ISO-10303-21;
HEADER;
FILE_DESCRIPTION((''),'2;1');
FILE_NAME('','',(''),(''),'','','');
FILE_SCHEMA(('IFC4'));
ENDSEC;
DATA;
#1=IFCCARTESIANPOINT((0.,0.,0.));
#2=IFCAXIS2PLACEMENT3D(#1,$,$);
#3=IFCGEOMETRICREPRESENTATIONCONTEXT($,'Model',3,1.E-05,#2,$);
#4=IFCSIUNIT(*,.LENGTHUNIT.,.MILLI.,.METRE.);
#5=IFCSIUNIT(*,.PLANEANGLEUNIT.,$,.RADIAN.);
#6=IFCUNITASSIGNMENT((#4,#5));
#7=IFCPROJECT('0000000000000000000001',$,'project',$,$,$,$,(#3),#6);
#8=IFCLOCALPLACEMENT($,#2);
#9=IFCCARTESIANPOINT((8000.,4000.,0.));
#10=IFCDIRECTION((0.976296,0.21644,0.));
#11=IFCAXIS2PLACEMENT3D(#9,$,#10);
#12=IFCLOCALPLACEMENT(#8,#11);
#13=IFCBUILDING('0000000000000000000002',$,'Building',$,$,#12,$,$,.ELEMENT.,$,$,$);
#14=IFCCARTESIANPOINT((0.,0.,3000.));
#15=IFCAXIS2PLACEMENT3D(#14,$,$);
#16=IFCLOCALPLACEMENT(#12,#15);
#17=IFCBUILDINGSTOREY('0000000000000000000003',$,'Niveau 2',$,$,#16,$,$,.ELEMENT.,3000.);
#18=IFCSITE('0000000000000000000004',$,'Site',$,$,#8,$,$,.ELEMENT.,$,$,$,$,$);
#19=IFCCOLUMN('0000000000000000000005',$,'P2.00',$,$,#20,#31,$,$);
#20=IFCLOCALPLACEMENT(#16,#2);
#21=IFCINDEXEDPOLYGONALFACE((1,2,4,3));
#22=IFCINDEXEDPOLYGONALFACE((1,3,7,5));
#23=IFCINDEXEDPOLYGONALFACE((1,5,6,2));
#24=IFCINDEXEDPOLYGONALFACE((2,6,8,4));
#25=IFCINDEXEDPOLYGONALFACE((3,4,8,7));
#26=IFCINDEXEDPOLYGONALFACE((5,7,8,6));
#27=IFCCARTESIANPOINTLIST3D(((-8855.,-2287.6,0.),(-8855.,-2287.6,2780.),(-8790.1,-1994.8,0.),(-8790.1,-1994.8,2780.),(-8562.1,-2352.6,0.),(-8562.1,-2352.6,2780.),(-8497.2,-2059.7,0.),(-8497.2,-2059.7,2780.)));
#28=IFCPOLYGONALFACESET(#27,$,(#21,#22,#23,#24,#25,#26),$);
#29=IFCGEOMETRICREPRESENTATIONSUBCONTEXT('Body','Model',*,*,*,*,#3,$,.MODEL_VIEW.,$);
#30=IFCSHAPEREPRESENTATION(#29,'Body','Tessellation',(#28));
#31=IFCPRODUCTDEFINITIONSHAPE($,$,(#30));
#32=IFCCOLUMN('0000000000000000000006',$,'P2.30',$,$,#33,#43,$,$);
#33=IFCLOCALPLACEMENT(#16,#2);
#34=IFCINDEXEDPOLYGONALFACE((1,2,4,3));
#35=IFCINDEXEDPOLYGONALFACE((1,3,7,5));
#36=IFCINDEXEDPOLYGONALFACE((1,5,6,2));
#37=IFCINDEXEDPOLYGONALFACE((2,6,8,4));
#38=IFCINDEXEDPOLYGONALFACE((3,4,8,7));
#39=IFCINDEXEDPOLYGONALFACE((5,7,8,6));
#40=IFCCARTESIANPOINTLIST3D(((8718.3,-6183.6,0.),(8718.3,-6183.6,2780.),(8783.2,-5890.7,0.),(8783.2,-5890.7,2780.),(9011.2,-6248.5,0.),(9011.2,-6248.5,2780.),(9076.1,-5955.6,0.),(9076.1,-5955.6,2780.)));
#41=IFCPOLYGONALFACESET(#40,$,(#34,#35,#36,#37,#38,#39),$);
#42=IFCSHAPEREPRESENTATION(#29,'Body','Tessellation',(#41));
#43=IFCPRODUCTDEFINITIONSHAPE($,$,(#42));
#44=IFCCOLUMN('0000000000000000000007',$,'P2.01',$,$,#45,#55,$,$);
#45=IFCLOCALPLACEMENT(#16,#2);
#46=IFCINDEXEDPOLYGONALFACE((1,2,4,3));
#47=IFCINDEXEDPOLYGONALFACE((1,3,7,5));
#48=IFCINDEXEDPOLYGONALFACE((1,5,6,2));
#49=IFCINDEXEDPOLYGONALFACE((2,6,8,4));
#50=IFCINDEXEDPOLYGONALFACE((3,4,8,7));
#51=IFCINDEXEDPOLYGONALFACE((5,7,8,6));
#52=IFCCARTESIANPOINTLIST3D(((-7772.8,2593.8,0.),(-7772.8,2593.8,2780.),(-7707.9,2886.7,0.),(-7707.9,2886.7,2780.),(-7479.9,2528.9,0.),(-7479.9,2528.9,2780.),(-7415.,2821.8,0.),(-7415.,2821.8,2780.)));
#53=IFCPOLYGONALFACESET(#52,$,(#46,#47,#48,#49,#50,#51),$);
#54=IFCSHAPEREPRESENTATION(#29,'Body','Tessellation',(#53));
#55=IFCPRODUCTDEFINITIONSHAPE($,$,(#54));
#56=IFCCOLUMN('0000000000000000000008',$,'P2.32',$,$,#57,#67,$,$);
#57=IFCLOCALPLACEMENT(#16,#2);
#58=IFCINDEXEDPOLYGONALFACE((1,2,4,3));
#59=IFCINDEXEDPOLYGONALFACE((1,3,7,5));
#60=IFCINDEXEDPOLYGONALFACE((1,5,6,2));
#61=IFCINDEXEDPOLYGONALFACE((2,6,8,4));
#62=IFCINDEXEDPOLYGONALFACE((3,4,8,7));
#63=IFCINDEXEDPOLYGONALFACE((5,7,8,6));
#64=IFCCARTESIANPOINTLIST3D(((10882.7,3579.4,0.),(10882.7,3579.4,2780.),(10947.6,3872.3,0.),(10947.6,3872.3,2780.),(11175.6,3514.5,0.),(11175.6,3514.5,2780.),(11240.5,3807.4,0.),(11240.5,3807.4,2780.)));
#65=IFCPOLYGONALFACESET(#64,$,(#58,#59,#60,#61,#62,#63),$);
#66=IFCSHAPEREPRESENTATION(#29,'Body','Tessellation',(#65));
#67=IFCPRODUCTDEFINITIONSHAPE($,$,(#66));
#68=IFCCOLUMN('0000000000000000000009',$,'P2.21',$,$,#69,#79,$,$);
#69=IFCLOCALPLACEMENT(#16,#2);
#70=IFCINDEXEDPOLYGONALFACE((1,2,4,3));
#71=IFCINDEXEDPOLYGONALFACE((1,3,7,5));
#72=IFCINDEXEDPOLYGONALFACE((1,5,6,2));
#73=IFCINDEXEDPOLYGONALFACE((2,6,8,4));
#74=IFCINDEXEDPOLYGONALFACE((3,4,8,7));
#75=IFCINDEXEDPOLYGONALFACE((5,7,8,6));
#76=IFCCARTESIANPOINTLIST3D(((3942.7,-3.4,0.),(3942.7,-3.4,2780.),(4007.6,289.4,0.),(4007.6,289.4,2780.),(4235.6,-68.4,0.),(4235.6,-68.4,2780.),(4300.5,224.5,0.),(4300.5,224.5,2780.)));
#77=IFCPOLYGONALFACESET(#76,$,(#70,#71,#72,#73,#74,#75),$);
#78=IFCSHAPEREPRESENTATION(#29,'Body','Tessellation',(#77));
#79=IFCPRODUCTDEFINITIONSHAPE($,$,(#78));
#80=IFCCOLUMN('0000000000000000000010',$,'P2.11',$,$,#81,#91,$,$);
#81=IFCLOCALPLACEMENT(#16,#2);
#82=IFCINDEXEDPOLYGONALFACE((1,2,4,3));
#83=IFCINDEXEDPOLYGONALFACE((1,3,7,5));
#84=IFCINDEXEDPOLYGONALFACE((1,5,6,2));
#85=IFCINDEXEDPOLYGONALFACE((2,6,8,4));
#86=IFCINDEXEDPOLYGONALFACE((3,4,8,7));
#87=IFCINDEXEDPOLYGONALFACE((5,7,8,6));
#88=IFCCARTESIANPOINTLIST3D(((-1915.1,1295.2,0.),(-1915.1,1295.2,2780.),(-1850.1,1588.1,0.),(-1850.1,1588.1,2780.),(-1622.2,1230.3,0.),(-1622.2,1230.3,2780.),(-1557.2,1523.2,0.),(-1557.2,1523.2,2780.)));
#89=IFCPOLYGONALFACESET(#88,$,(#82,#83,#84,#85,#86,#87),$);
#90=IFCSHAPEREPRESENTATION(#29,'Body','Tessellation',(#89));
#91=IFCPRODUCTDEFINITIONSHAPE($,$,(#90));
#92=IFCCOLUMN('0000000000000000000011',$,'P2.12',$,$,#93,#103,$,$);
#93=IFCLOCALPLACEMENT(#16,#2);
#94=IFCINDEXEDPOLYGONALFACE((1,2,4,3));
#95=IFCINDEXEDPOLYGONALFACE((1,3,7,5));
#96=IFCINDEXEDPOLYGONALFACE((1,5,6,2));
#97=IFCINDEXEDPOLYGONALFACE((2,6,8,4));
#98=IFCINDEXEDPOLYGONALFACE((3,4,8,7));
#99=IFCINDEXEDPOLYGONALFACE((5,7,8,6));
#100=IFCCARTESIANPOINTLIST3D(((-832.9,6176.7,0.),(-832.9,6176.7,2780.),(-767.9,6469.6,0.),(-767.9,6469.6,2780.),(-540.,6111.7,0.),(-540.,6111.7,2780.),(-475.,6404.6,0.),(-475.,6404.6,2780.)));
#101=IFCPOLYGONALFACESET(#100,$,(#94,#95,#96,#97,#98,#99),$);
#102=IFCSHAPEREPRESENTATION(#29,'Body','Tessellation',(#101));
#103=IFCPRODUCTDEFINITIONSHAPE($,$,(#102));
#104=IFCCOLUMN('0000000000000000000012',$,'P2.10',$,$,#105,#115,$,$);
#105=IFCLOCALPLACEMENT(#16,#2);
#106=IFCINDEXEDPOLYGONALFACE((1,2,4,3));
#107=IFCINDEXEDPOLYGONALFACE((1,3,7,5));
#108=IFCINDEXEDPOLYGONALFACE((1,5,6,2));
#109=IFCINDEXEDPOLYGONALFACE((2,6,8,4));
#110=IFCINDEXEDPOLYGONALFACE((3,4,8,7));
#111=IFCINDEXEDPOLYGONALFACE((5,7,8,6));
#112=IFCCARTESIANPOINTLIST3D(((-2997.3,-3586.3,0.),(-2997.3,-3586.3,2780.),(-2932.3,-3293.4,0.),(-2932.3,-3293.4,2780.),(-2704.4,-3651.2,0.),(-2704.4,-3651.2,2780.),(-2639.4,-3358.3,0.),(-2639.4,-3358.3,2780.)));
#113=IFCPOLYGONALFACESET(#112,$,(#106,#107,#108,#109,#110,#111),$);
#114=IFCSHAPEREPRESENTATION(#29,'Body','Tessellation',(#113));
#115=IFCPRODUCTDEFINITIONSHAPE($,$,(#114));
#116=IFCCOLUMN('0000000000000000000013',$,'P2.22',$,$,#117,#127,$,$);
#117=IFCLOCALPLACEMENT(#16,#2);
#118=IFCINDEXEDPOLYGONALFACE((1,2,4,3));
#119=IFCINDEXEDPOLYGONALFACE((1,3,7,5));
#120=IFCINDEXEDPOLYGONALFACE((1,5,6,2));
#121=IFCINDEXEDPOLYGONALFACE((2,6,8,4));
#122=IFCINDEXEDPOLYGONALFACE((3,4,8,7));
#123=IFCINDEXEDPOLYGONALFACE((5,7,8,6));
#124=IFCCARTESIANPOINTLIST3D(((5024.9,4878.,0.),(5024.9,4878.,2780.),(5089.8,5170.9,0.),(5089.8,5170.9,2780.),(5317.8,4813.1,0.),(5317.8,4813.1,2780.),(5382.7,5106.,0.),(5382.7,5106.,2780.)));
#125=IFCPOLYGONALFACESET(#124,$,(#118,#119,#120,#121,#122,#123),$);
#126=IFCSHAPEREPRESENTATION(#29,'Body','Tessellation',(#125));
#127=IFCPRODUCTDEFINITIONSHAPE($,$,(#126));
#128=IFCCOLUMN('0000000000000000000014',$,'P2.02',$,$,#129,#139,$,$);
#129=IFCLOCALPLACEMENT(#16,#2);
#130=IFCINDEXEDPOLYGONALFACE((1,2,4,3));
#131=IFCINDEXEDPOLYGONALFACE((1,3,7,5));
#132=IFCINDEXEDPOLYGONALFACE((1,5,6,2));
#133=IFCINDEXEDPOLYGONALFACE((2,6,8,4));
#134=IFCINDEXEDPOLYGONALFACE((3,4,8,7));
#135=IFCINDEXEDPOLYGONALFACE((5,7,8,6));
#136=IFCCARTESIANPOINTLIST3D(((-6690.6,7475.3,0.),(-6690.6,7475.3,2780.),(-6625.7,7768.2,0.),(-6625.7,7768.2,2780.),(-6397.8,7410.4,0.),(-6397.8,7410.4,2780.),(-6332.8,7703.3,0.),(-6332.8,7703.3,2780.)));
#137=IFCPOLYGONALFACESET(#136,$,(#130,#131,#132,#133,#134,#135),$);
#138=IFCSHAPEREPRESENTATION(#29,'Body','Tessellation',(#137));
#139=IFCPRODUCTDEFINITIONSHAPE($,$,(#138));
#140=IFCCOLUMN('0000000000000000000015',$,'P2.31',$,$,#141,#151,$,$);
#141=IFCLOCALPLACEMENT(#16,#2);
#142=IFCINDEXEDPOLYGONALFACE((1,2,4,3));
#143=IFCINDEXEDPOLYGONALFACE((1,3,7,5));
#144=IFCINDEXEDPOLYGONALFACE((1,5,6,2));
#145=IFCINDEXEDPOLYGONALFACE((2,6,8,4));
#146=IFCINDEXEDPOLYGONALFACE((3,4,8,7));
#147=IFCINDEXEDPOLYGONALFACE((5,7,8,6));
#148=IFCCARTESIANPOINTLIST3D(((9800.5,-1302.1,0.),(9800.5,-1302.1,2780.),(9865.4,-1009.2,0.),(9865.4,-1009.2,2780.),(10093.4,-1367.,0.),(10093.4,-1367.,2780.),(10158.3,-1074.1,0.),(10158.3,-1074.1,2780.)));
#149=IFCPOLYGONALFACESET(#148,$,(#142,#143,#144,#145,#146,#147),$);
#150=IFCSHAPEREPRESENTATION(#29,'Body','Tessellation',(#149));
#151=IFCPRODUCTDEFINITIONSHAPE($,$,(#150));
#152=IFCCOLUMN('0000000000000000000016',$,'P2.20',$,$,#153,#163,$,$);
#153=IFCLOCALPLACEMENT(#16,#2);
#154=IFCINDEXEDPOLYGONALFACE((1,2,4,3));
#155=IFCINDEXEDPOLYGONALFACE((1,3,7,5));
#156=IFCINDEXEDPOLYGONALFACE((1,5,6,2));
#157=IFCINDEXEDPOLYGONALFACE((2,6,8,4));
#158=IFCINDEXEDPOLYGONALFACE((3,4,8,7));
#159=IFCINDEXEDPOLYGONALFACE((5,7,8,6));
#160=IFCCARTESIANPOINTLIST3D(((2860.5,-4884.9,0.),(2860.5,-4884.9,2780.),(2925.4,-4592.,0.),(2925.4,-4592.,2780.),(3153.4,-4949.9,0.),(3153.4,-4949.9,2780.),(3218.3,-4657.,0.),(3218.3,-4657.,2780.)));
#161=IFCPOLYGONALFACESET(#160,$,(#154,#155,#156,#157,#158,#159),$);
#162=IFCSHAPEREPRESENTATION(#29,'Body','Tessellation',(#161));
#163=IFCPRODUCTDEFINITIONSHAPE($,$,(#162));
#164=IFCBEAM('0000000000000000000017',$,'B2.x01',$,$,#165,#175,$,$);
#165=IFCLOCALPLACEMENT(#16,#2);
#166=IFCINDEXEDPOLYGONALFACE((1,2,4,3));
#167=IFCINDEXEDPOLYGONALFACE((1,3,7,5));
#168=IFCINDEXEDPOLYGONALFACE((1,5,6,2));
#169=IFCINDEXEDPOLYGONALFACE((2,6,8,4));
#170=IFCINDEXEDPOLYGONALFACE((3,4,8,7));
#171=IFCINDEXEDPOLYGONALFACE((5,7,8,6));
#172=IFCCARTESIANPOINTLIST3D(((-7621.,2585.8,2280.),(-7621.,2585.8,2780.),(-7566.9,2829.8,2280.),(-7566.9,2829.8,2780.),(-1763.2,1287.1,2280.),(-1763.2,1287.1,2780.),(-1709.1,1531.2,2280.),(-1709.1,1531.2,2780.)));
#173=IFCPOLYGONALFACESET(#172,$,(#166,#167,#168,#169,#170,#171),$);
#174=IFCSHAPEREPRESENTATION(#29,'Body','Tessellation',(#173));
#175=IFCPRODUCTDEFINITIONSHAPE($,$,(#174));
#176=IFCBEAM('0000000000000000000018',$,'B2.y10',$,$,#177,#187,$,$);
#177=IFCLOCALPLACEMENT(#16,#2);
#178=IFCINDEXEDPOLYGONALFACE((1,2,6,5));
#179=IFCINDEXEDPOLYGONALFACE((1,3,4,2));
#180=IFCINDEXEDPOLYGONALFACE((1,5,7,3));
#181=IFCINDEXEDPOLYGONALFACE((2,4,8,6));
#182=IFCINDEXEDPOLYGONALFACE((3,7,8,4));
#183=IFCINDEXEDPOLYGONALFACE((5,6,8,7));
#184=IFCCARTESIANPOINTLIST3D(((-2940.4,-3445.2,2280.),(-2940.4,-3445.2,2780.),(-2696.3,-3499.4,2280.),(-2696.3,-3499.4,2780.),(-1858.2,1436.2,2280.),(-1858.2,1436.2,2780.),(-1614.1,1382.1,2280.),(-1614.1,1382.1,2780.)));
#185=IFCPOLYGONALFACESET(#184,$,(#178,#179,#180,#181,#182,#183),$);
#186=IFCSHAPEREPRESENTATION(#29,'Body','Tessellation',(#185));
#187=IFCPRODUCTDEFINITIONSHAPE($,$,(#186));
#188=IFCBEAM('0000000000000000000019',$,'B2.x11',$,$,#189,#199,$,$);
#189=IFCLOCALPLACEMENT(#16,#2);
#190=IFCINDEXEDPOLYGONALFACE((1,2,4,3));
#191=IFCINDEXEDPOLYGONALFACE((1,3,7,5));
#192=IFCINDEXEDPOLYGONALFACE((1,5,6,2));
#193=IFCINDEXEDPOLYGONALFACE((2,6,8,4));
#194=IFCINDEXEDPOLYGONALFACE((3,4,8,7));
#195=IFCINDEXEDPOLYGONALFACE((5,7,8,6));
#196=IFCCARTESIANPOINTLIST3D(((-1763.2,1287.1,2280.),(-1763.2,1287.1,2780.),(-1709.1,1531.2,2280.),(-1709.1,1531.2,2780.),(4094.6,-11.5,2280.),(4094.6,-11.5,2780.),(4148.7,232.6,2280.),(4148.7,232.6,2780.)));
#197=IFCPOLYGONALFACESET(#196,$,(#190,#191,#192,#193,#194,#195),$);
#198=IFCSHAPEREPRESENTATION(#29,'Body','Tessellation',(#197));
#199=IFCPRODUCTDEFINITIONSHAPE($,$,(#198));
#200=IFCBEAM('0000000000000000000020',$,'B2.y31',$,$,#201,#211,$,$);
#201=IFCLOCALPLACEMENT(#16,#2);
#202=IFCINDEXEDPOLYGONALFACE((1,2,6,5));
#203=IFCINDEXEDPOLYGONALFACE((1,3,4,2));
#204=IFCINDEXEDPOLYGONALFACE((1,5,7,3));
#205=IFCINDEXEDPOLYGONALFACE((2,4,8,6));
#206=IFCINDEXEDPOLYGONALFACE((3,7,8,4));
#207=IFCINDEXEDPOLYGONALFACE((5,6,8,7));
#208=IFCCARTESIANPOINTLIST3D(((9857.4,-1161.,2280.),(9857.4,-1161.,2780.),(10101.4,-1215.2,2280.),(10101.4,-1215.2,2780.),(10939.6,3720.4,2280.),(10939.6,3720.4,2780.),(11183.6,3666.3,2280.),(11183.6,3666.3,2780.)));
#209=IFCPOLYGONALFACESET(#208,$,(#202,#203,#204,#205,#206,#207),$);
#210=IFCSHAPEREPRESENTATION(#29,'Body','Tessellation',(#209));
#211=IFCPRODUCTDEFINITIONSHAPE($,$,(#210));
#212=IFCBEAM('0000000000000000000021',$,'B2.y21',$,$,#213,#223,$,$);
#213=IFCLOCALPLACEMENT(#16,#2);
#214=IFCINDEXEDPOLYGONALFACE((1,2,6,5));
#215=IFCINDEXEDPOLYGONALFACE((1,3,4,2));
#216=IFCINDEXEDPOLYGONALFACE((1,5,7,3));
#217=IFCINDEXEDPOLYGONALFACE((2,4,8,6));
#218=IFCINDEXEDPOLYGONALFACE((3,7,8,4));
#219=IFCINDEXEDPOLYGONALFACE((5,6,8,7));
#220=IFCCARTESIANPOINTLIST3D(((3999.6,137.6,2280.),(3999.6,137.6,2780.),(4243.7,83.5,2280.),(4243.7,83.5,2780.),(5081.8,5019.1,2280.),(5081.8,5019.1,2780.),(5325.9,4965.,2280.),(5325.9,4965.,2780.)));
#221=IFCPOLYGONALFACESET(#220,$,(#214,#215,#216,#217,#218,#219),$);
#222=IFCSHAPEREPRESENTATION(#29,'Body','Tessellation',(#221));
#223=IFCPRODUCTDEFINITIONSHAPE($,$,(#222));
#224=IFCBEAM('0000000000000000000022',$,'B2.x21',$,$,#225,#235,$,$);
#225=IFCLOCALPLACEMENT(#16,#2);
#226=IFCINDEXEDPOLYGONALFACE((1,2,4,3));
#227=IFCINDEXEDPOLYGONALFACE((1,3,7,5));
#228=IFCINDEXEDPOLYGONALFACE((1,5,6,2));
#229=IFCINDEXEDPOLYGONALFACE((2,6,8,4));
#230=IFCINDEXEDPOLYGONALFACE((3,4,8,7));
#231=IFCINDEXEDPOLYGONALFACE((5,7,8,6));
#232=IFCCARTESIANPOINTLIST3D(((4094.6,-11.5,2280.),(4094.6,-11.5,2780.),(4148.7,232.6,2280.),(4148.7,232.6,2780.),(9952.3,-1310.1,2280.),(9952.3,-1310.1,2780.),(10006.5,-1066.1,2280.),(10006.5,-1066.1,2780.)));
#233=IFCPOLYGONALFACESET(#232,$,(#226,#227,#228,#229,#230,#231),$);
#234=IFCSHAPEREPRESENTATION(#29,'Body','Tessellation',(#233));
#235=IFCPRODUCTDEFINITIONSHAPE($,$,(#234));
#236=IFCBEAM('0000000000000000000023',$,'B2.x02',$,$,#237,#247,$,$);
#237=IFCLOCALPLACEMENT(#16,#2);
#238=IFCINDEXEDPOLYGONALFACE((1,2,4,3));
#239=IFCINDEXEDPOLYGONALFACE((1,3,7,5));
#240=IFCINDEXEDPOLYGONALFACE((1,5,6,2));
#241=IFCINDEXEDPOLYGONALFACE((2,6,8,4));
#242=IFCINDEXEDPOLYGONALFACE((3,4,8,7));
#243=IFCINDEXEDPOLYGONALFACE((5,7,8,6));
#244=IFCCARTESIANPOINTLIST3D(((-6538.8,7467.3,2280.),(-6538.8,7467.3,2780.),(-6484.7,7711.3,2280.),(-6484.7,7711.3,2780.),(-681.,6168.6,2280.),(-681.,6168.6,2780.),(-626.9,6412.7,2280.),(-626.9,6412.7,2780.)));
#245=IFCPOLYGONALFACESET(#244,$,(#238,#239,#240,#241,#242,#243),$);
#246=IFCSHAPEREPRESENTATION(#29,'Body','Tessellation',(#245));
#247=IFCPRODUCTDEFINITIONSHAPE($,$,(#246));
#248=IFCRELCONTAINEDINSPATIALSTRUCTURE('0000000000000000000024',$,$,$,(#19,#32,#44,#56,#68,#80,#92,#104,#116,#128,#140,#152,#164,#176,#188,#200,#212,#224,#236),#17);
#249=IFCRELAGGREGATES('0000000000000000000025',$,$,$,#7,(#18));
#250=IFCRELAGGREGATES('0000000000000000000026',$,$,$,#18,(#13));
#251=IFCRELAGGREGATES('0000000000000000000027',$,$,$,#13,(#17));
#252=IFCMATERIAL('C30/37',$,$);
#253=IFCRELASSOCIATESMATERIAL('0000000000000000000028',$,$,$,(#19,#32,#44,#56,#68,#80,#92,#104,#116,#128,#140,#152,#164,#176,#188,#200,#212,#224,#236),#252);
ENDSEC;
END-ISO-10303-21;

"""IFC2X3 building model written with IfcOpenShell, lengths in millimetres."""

from ifc_helpers import new_model, si_unit, frame, origin, origin_2d, place, context, subcontext, project, spatial, rectangle, extrude, material, element, save


model = new_model("IFC2X3")

# Units and contexts
model_context = context("Model", 3, precision=1e-05, world=origin())
body_context = subcontext(model_context, "Body", "Model", "MODEL_VIEW")
ifc_project = project(units=[si_unit("LENGTHUNIT", "METRE", prefix="MILLI"), si_unit("PLANEANGLEUNIT", "RADIAN")], contexts=[model_context])

# Site, building, storey
site_placement = place(None, origin())
site = spatial("IfcSite", under=ifc_project, at=site_placement, Name="Site", CompositionType="ELEMENT")
building_placement = place(site_placement, frame((8000.0, 4000.0, 0.0), x_axis=(0.976296, 0.21644, 0.0)))
building = spatial("IfcBuilding", under=site, at=building_placement, Name="Building", CompositionType="ELEMENT")
storey_placement = place(building_placement, frame((0.0, 0.0, 3000.0)))
storey = spatial("IfcBuildingStorey", under=building, at=storey_placement, Name="Niveau 2", CompositionType="ELEMENT", Elevation=3000.0)

# Columns
ifc_material = material(Name="C30/37")
for number, where, z_axis, x_axis, name in (
    (1, (-8676.1, -2173.7, 0.0), (0.0, 0.0, 1.0), (0.976296, -0.21644, 0.0), "P2.00"),
    (2, (8897.2, -6069.6, 0.0), (0.0, 0.0, 1.0), (0.976296, -0.21644, 0.0), "P2.30"),
    (3, (-7593.9, 2707.8, 0.0), (0.0, 0.0, 1.0), (0.976296, -0.21644, 0.0), "P2.01"),
    (4, (11061.6, 3693.4, 0.0), (0.0, 0.0, 1.0), (0.976296, -0.21644, 0.0), "P2.32"),
    (5, (4121.6, 110.5, 0.0), (0.0, 0.0, 1.0), (0.976296, -0.21644, 0.0), "P2.21"),
    (6, (-1736.2, 1409.2, 0.0), (0.0, 0.0, 1.0), (0.976296, -0.21644, 0.0), "P2.11"),
    (7, (-654.0, 6290.7, 0.0), (0.0, 0.0, 1.0), (0.976296, -0.21644, 0.0), "P2.12"),
    (8, (-2818.4, -3472.3, 0.0), (0.0, 0.0, 1.0), (0.976296, -0.21644, 0.0), "P2.10"),
    (9, (5203.8, 4992.0, 0.0), (0.0, 0.0, 1.0), (0.976296, -0.21644, 0.0), "P2.22"),
    (10, (-6511.7, 7589.3, 0.0), (0.0, 0.0, 1.0), (0.976296, -0.21644, 0.0), "P2.02"),
    (11, (9979.4, -1188.1, 0.0), (0.0, 0.0, 1.0), (0.976296, -0.21644, 0.0), "P2.31"),
    (12, (3039.4, -4770.9, 0.0), (0.0, 0.0, 1.0), (0.976296, -0.21644, 0.0), "P2.20"),
):
    element("IfcColumn", number, at=place(storey_placement, frame(where, z_axis=z_axis, x_axis=x_axis)), inside=storey, material=ifc_material, Name=name, context=body_context, shape_type="SweptSolid", body=[
        extrude(rectangle(XDim=300.0, YDim=300.0, at=origin_2d()), origin(), (0.0, 0.0, 1.0), 2780.0),
    ])

# Beams
beam_1_placement = place(storey_placement, frame((-7593.9, 2707.8, 2530.0), z_axis=(0.976296, -0.21644, 0.0), x_axis=(0.21644, 0.976296, 0.0)))
element("IfcBeam", 13, at=beam_1_placement, inside=storey, material=ifc_material, Name="B2.x01", context=body_context, shape_type="SweptSolid", body=[
    extrude(rectangle(XDim=250.0, YDim=500.0, at=origin_2d()), origin(), (0.0, 0.0, 1.0), 6000.0),
])
beam_2_placement = place(storey_placement, frame((-2818.4, -3472.3, 2530.0), z_axis=(0.21644, 0.976296, 0.0), x_axis=(-0.976296, 0.21644, 0.0)))
element("IfcBeam", 14, at=beam_2_placement, inside=storey, material=ifc_material, Name="B2.y10", context=body_context, shape_type="SweptSolid", body=[
    extrude(rectangle(XDim=250.0, YDim=500.0, at=origin_2d()), origin(), (0.0, 0.0, 1.0), 5000.0),
])
beam_3_placement = place(storey_placement, frame((-1736.2, 1409.2, 2530.0), z_axis=(0.976296, -0.21644, 0.0), x_axis=(0.21644, 0.976296, 0.0)))
element("IfcBeam", 15, at=beam_3_placement, inside=storey, material=ifc_material, Name="B2.x11", context=body_context, shape_type="SweptSolid", body=[
    extrude(rectangle(XDim=250.0, YDim=500.0, at=origin_2d()), origin(), (0.0, 0.0, 1.0), 6000.0),
])
for number, where, z_axis, x_axis, name in (
    (16, (9979.4, -1188.1, 2530.0), (0.21644, 0.976296, 0.0), (-0.976296, 0.21644, 0.0), "B2.y31"),
    (17, (4121.6, 110.5, 2530.0), (0.21644, 0.976296, 0.0), (-0.976296, 0.21644, 0.0), "B2.y21"),
):
    element("IfcBeam", number, at=place(storey_placement, frame(where, z_axis=z_axis, x_axis=x_axis)), inside=storey, material=ifc_material, Name=name, context=body_context, shape_type="SweptSolid", body=[
        extrude(rectangle(XDim=250.0, YDim=500.0, at=origin_2d()), origin(), (0.0, 0.0, 1.0), 5000.0),
    ])
for number, where, z_axis, x_axis, name in (
    (18, (4121.6, 110.5, 2530.0), (0.976296, -0.21644, 0.0), (0.21644, 0.976296, 0.0), "B2.x21"),
    (19, (-6511.7, 7589.3, 2530.0), (0.976296, -0.21644, 0.0), (0.21644, 0.976296, 0.0), "B2.x02"),
):
    element("IfcBeam", number, at=place(storey_placement, frame(where, z_axis=z_axis, x_axis=x_axis)), inside=storey, material=ifc_material, Name=name, context=body_context, shape_type="SweptSolid", body=[
        extrude(rectangle(XDim=250.0, YDim=500.0, at=origin_2d()), origin(), (0.0, 0.0, 1.0), 6000.0),
    ])

save(model, "model.ifc")
